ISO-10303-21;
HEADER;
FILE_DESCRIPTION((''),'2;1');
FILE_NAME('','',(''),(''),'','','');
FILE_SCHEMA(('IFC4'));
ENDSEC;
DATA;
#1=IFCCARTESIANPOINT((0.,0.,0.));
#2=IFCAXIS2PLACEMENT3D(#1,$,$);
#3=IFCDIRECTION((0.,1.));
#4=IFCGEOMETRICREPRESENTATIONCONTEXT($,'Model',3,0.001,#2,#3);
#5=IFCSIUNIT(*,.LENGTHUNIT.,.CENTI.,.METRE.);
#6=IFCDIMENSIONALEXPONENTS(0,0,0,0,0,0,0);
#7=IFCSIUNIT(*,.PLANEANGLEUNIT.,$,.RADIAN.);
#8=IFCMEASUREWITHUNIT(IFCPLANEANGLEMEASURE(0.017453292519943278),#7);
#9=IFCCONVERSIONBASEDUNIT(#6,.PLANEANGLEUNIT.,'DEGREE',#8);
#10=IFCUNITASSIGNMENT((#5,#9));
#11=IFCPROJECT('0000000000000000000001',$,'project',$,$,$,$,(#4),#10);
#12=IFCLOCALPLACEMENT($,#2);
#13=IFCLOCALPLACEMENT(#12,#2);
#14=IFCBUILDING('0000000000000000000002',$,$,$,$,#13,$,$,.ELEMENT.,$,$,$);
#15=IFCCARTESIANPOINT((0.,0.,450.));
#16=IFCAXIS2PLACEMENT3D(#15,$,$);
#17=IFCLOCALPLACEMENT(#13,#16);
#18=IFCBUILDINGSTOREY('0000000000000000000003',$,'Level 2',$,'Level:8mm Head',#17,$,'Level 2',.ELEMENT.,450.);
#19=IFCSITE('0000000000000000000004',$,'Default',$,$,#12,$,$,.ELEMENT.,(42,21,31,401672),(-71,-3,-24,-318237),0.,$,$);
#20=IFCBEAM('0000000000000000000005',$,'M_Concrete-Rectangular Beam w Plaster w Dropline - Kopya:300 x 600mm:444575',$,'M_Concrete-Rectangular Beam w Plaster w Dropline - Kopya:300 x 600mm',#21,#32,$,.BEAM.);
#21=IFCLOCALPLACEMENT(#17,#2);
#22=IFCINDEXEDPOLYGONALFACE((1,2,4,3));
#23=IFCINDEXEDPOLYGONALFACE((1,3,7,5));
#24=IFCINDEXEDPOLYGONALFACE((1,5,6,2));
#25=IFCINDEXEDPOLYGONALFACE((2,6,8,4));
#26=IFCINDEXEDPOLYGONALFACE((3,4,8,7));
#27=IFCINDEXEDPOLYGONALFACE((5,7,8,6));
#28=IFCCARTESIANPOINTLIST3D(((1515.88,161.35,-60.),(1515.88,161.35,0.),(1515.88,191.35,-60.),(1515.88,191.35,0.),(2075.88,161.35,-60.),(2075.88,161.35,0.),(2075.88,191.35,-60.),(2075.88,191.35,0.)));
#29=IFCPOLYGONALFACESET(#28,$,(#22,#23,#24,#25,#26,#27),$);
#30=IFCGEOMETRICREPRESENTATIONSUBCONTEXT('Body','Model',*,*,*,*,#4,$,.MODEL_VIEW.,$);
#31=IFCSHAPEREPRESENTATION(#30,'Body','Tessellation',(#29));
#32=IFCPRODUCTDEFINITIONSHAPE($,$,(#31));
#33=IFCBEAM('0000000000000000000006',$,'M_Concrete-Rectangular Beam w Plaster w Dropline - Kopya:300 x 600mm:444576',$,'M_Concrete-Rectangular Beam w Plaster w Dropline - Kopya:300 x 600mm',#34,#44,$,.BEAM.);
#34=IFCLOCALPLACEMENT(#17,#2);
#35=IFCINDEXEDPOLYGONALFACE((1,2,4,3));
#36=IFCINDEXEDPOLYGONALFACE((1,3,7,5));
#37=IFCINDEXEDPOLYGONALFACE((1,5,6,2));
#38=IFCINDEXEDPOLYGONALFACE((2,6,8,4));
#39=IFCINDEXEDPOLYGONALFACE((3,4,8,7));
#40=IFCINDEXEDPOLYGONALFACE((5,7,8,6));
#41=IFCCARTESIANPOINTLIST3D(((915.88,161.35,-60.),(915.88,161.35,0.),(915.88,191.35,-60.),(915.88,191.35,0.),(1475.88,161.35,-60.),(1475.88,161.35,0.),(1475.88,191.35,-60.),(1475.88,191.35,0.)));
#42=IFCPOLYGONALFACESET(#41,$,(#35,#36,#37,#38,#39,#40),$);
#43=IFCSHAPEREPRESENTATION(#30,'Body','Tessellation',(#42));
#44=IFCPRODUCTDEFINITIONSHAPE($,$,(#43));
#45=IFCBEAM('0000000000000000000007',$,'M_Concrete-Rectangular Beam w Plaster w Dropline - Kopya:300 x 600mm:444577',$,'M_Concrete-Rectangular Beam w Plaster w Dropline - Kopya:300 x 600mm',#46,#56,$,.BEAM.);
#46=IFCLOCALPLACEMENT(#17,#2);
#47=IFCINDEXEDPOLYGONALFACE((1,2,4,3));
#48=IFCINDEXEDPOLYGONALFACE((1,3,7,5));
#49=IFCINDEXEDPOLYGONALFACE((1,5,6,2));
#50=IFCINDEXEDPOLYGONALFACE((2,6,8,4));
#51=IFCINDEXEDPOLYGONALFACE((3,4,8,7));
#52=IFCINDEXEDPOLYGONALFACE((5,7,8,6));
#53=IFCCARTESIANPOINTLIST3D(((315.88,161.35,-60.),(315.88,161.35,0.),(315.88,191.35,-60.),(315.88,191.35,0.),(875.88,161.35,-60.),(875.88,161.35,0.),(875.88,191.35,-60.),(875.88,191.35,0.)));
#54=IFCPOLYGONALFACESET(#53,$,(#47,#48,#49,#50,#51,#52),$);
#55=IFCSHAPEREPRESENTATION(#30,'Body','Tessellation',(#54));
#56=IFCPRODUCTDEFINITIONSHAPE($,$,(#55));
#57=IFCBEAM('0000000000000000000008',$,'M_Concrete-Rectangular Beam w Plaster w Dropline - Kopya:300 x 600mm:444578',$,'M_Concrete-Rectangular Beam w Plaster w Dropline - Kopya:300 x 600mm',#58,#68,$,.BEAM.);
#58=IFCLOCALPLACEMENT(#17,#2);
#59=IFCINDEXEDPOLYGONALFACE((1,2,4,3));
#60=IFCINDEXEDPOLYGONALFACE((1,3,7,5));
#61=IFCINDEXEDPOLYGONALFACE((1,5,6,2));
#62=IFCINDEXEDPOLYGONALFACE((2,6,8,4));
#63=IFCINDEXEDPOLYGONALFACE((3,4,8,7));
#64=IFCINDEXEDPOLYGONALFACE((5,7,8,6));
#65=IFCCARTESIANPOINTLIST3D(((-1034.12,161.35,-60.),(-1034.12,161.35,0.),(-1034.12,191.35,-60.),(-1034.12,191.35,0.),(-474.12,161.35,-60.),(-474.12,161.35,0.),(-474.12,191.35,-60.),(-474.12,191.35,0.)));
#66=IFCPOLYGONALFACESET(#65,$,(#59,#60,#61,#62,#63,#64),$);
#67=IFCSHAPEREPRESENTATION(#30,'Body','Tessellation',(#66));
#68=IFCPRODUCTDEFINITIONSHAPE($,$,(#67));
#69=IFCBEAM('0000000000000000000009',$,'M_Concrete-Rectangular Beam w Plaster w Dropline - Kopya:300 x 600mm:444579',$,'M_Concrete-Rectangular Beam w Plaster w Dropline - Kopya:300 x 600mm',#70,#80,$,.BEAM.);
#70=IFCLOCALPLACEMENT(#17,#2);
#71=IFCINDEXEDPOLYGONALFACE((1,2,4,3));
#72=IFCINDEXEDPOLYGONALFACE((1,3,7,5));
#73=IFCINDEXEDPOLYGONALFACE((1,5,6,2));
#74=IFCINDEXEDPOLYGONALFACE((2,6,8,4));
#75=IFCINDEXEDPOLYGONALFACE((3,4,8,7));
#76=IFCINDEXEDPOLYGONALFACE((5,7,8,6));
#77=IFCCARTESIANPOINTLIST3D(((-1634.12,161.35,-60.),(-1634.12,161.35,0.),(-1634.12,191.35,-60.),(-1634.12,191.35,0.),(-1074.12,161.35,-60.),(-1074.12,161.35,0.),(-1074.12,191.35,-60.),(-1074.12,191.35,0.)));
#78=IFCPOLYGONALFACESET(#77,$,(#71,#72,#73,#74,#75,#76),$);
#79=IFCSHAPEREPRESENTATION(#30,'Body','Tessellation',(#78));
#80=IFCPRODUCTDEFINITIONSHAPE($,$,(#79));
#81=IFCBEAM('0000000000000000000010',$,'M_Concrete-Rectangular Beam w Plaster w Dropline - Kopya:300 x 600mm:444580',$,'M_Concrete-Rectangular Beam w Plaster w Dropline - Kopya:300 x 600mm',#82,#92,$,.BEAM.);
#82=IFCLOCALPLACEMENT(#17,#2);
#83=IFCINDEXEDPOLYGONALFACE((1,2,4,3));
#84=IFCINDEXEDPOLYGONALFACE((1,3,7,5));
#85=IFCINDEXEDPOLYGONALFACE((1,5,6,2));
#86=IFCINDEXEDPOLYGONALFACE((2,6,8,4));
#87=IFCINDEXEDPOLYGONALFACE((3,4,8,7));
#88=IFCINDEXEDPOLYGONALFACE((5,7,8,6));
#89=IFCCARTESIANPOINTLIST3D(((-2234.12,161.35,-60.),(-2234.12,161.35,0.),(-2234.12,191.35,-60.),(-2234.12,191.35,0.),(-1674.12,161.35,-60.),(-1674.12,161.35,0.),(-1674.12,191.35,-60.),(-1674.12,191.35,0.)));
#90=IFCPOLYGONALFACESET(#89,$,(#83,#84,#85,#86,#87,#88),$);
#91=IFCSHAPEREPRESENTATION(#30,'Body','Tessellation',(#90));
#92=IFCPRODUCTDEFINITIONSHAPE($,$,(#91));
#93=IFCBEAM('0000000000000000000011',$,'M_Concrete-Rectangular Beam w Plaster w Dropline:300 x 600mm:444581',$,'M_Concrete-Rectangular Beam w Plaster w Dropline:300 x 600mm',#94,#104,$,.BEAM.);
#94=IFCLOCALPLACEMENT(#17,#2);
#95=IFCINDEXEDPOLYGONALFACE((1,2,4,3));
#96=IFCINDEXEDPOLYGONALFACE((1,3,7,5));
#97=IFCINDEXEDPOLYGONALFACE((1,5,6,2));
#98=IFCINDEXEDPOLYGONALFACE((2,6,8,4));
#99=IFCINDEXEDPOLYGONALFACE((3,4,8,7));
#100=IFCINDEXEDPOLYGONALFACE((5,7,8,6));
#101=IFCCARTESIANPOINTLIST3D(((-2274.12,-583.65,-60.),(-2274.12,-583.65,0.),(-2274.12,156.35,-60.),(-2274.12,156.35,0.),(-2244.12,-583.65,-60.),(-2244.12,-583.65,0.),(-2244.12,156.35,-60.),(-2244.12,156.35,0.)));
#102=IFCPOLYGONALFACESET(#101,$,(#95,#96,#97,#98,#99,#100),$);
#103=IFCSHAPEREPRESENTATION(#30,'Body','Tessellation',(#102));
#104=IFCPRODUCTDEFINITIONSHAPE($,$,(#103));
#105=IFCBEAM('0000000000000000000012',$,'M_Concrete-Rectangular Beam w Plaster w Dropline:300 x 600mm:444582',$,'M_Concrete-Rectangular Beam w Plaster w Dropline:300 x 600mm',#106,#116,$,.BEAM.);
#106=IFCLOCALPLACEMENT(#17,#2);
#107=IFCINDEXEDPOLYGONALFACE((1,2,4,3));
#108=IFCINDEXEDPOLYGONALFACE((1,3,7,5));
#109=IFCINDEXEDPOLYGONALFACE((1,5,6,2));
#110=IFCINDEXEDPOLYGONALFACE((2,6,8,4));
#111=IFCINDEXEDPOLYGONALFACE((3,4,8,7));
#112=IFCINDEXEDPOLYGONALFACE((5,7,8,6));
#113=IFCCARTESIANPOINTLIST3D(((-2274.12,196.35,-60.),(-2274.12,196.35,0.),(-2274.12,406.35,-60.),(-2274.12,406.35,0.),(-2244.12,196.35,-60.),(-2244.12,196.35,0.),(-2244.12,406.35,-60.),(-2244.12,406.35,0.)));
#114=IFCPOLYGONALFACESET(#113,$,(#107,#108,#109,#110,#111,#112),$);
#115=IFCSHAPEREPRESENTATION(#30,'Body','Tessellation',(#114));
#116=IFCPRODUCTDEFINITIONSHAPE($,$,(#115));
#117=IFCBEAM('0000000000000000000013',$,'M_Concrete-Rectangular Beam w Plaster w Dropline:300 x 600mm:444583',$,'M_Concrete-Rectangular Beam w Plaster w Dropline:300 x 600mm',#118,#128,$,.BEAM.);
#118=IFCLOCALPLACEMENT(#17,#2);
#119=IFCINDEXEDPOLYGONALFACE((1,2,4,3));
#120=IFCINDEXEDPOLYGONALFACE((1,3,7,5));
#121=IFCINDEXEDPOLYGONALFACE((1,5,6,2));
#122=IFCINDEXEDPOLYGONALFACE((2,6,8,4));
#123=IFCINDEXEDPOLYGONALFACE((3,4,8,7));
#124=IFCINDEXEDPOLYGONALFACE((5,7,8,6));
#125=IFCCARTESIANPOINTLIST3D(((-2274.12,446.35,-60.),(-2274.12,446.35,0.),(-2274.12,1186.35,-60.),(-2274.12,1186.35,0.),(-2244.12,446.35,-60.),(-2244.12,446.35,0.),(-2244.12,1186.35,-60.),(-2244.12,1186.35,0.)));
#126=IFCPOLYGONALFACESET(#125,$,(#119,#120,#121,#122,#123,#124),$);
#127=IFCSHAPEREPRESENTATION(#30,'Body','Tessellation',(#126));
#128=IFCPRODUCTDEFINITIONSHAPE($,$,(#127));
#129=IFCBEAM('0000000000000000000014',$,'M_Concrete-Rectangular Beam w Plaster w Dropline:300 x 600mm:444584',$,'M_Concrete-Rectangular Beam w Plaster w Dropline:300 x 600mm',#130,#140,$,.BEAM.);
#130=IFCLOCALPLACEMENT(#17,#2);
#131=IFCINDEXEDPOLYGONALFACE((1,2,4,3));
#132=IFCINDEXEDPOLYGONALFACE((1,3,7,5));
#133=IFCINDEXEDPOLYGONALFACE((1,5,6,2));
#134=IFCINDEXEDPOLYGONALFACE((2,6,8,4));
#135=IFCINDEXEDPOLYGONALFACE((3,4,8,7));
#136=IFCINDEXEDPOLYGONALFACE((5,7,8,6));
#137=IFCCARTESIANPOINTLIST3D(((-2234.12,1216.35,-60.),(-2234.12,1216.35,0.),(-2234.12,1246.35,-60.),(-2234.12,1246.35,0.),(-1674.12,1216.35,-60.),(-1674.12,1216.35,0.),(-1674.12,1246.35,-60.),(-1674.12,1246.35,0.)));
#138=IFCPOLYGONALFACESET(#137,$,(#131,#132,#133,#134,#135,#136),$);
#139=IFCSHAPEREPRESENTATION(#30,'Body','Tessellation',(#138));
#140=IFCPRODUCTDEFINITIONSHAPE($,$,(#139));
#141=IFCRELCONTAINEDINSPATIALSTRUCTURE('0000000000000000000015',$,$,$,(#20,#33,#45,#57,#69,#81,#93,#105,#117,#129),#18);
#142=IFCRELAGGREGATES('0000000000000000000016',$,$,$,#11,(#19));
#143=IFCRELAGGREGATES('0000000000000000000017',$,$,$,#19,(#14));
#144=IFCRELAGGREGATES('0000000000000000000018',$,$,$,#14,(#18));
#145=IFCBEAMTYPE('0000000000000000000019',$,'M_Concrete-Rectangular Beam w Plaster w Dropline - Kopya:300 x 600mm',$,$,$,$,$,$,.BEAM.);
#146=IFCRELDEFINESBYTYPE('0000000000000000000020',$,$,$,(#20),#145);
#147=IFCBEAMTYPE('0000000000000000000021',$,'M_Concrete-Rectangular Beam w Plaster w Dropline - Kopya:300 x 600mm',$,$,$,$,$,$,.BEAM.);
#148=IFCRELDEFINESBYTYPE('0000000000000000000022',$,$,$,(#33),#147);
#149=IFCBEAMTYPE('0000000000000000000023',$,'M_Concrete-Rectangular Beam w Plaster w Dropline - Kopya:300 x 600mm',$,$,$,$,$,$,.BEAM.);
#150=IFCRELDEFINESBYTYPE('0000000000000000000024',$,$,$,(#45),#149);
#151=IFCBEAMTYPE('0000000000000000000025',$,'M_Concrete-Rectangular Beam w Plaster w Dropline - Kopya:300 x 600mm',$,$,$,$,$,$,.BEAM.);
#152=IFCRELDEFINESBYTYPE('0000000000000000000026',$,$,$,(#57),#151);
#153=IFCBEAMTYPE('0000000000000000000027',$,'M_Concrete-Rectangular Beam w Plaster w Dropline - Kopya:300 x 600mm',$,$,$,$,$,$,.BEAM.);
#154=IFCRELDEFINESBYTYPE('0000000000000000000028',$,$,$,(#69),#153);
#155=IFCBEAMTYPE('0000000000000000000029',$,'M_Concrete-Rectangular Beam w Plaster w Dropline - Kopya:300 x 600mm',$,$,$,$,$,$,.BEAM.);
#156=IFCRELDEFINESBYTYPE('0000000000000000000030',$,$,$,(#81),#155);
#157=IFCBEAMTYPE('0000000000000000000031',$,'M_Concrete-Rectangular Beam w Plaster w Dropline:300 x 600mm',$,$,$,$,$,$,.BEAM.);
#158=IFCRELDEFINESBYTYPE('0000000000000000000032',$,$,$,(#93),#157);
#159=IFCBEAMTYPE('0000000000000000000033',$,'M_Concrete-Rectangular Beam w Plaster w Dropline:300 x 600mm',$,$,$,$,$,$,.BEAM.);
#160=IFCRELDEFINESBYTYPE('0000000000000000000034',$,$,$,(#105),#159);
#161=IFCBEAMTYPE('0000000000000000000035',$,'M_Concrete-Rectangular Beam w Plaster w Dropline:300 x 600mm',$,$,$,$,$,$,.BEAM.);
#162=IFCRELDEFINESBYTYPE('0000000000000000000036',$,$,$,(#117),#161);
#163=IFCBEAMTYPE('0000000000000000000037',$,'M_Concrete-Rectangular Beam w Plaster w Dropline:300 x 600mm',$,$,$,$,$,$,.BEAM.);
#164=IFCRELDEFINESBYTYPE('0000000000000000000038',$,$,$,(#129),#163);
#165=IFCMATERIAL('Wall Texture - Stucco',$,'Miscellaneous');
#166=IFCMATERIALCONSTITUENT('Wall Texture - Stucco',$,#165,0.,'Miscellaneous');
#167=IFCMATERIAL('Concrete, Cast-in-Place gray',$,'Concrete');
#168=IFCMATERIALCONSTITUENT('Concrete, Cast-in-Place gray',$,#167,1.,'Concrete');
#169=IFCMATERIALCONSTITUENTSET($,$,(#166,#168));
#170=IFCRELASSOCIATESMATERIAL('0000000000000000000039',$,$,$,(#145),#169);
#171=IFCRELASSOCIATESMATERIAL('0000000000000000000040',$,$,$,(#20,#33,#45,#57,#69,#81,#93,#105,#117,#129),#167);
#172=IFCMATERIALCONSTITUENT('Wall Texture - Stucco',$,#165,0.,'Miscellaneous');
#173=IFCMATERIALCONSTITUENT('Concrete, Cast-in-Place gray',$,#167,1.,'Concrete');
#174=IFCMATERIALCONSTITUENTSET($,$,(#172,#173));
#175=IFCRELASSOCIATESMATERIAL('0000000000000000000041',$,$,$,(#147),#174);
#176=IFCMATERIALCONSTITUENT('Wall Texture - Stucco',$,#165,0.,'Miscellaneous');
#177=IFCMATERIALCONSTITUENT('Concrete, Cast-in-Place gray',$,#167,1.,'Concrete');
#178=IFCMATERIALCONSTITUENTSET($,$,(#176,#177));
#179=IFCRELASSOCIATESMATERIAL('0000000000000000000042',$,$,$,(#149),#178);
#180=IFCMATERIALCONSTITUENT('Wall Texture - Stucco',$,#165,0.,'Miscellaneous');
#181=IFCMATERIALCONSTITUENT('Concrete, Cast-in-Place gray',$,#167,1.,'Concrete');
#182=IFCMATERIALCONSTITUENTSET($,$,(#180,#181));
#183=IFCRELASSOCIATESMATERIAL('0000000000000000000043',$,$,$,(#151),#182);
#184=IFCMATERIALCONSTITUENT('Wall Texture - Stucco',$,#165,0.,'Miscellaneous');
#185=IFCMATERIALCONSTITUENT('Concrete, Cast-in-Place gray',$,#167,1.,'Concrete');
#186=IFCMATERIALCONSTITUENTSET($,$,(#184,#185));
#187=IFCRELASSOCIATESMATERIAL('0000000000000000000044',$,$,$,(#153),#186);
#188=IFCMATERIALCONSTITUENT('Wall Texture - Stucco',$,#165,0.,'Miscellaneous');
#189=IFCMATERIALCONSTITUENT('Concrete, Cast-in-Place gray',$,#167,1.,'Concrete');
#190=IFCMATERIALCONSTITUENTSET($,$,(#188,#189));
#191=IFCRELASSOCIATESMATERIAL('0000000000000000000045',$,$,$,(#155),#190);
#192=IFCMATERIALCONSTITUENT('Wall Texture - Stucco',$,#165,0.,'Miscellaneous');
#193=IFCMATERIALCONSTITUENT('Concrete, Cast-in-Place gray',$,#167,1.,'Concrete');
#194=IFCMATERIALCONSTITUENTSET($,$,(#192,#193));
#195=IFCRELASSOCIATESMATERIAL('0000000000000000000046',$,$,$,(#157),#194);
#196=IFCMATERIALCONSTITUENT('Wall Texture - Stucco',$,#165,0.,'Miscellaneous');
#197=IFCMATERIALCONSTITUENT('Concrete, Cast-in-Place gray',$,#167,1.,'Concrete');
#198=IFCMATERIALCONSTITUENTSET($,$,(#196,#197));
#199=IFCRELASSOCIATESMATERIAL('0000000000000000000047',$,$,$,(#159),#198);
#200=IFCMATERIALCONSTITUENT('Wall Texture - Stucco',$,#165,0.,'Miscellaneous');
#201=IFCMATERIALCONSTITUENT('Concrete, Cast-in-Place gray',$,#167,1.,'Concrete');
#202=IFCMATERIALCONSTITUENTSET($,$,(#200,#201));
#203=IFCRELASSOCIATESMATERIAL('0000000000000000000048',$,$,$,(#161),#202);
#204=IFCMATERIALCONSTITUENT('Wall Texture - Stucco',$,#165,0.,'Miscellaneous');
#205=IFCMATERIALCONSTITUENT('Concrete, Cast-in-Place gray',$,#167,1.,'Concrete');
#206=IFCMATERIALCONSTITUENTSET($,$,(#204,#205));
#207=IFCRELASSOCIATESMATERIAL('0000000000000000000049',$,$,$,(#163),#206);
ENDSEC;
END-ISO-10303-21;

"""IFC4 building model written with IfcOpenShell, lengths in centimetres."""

from ifc_helpers import new_model, entity, si_unit, converted_unit, direction, frame, origin, place, context, subcontext, project, spatial, indexed_curve, outline, extrude, source, transform, mapped, material, constituent, constituent_set, type_object, type_shapes, element, save


model = new_model("IFC4")

# Units and contexts
model_context = context("Model", 3, precision=0.001, world=origin(), true_north=direction((0.0, 1.0)))
body_context = subcontext(model_context, "Body", "Model", "MODEL_VIEW")
ifc_project = project(units=[si_unit("LENGTHUNIT", "METRE", prefix="CENTI"), converted_unit("PLANEANGLEUNIT", "DEGREE", entity("IfcPlaneAngleMeasure", 0.017453292519943278), si_unit("PLANEANGLEUNIT", "RADIAN"), dimensions=[0, 0, 0, 0, 0, 0, 0])], contexts=[model_context])

# Site, building, storey
site_placement = place(None, origin())
site = spatial("IfcSite", under=ifc_project, at=site_placement, Name="Default", CompositionType="ELEMENT", RefLatitude=(42, 21, 31, 401672), RefLongitude=(-71, -3, -24, -318237), RefElevation=0.0)
building_placement = place(site_placement, origin())
building = spatial("IfcBuilding", under=site, at=building_placement, CompositionType="ELEMENT")
storey_placement = place(building_placement, frame((0.0, 0.0, 450.0)))
storey = spatial("IfcBuildingStorey", under=building, at=storey_placement, Name="Level 2", ObjectType="Level:8mm Head", LongName="Level 2", CompositionType="ELEMENT", Elevation=450.0)

# Beams
ifc_material_1 = material(Name="Concrete, Cast-in-Place gray", Category="Concrete")
ifc_material_2 = material(Name="Wall Texture - Stucco", Category="Miscellaneous")
ifc_constituent_1 = constituent(ifc_material_2, Name="Wall Texture - Stucco", Category="Miscellaneous", fraction=0.0)
ifc_constituent_2 = constituent(ifc_material_1, Name="Concrete, Cast-in-Place gray", Category="Concrete", fraction=1.0)
ifc_constituent_set_1 = constituent_set(constituents=[ifc_constituent_1, ifc_constituent_2])
beam_type_1 = type_object("IfcBeamType", Name="M_Concrete-Rectangular Beam w Plaster w Dropline - Kopya:300 x 600mm", PredefinedType="BEAM", material=ifc_constituent_set_1)
shared_shape_1 = source(origin(), body_context, "Body", "SweptSolid", [
    extrude(outline(indexed_curve([(-30.0, -15.0), (30.0, -15.0), (30.0, 15.0), (-30.0, 15.0), (-30.0, -15.0)], self_intersect=False)), frame((2075.88, 176.35, 420.0), z_axis=(-1.0, 0.0, 0.0), x_axis=(0.0, 0.0, -1.0)), (0.0, 0.0, 1.0), 560.0),
])
type_shapes(beam_type_1, [shared_shape_1])
beam_1_placement = place(storey_placement, frame((0.0, 0.0, -450.0)))
element("IfcBeam", 1, at=beam_1_placement, inside=storey, type_object=beam_type_1, material=ifc_material_1, Name="M_Concrete-Rectangular Beam w Plaster w Dropline - Kopya:300 x 600mm:444575", ObjectType="M_Concrete-Rectangular Beam w Plaster w Dropline - Kopya:300 x 600mm", PredefinedType="BEAM", context=body_context, shape_type="MappedRepresentation", body=[
    mapped(shared_shape_1, transform((0.0, 0.0, 0.0), scale=1.0)),
])
ifc_constituent_3 = constituent(ifc_material_2, Name="Wall Texture - Stucco", Category="Miscellaneous", fraction=0.0)
ifc_constituent_4 = constituent(ifc_material_1, Name="Concrete, Cast-in-Place gray", Category="Concrete", fraction=1.0)
ifc_constituent_set_2 = constituent_set(constituents=[ifc_constituent_3, ifc_constituent_4])
beam_type_2 = type_object("IfcBeamType", Name="M_Concrete-Rectangular Beam w Plaster w Dropline - Kopya:300 x 600mm", PredefinedType="BEAM", material=ifc_constituent_set_2)
shared_shape_2 = source(origin(), body_context, "Body", "SweptSolid", [
    extrude(outline(indexed_curve([(-30.0, -15.0), (30.0, -15.0), (30.0, 15.0), (-30.0, 15.0), (-30.0, -15.0)], self_intersect=False)), frame((1475.88, 176.35, 420.0), z_axis=(-1.0, 0.0, 0.0), x_axis=(0.0, 0.0, -1.0)), (0.0, 0.0, 1.0), 560.0),
])
type_shapes(beam_type_2, [shared_shape_2])
beam_2_placement = place(storey_placement, frame((0.0, 0.0, -450.0)))
element("IfcBeam", 2, at=beam_2_placement, inside=storey, type_object=beam_type_2, material=ifc_material_1, Name="M_Concrete-Rectangular Beam w Plaster w Dropline - Kopya:300 x 600mm:444576", ObjectType="M_Concrete-Rectangular Beam w Plaster w Dropline - Kopya:300 x 600mm", PredefinedType="BEAM", context=body_context, shape_type="MappedRepresentation", body=[
    mapped(shared_shape_2, transform((0.0, 0.0, 0.0), scale=1.0)),
])
ifc_constituent_5 = constituent(ifc_material_2, Name="Wall Texture - Stucco", Category="Miscellaneous", fraction=0.0)
ifc_constituent_6 = constituent(ifc_material_1, Name="Concrete, Cast-in-Place gray", Category="Concrete", fraction=1.0)
ifc_constituent_set_3 = constituent_set(constituents=[ifc_constituent_5, ifc_constituent_6])
beam_type_3 = type_object("IfcBeamType", Name="M_Concrete-Rectangular Beam w Plaster w Dropline - Kopya:300 x 600mm", PredefinedType="BEAM", material=ifc_constituent_set_3)
shared_shape_3 = source(origin(), body_context, "Body", "SweptSolid", [
    extrude(outline(indexed_curve([(-30.0, -15.0), (30.0, -15.0), (30.0, 15.0), (-30.0, 15.0), (-30.0, -15.0)], self_intersect=False)), frame((875.88, 176.35, 420.0), z_axis=(-1.0, 0.0, 0.0), x_axis=(0.0, 0.0, -1.0)), (0.0, 0.0, 1.0), 560.0),
])
type_shapes(beam_type_3, [shared_shape_3])
beam_3_placement = place(storey_placement, frame((0.0, 0.0, -450.0)))
element("IfcBeam", 3, at=beam_3_placement, inside=storey, type_object=beam_type_3, material=ifc_material_1, Name="M_Concrete-Rectangular Beam w Plaster w Dropline - Kopya:300 x 600mm:444577", ObjectType="M_Concrete-Rectangular Beam w Plaster w Dropline - Kopya:300 x 600mm", PredefinedType="BEAM", context=body_context, shape_type="MappedRepresentation", body=[
    mapped(shared_shape_3, transform((0.0, 0.0, 0.0), scale=1.0)),
])
ifc_constituent_7 = constituent(ifc_material_2, Name="Wall Texture - Stucco", Category="Miscellaneous", fraction=0.0)
ifc_constituent_8 = constituent(ifc_material_1, Name="Concrete, Cast-in-Place gray", Category="Concrete", fraction=1.0)
ifc_constituent_set_4 = constituent_set(constituents=[ifc_constituent_7, ifc_constituent_8])
beam_type_4 = type_object("IfcBeamType", Name="M_Concrete-Rectangular Beam w Plaster w Dropline - Kopya:300 x 600mm", PredefinedType="BEAM", material=ifc_constituent_set_4)
shared_shape_4 = source(origin(), body_context, "Body", "SweptSolid", [
    extrude(outline(indexed_curve([(-30.0, -15.0), (30.0, -15.0), (30.0, 15.0), (-30.0, 15.0), (-30.0, -15.0)], self_intersect=False)), frame((-474.12, 176.35, 420.0), z_axis=(-1.0, 0.0, 0.0), x_axis=(0.0, 0.0, -1.0)), (0.0, 0.0, 1.0), 560.0),
])
type_shapes(beam_type_4, [shared_shape_4])
beam_4_placement = place(storey_placement, frame((0.0, 0.0, -450.0)))
element("IfcBeam", 4, at=beam_4_placement, inside=storey, type_object=beam_type_4, material=ifc_material_1, Name="M_Concrete-Rectangular Beam w Plaster w Dropline - Kopya:300 x 600mm:444578", ObjectType="M_Concrete-Rectangular Beam w Plaster w Dropline - Kopya:300 x 600mm", PredefinedType="BEAM", context=body_context, shape_type="MappedRepresentation", body=[
    mapped(shared_shape_4, transform((0.0, 0.0, 0.0), scale=1.0)),
])
ifc_constituent_9 = constituent(ifc_material_2, Name="Wall Texture - Stucco", Category="Miscellaneous", fraction=0.0)
ifc_constituent_10 = constituent(ifc_material_1, Name="Concrete, Cast-in-Place gray", Category="Concrete", fraction=1.0)
ifc_constituent_set_5 = constituent_set(constituents=[ifc_constituent_9, ifc_constituent_10])
beam_type_5 = type_object("IfcBeamType", Name="M_Concrete-Rectangular Beam w Plaster w Dropline - Kopya:300 x 600mm", PredefinedType="BEAM", material=ifc_constituent_set_5)
shared_shape_5 = source(origin(), body_context, "Body", "SweptSolid", [
    extrude(outline(indexed_curve([(-30.0, -15.0), (30.0, -15.0), (30.0, 15.0), (-30.0, 15.0), (-30.0, -15.0)], self_intersect=False)), frame((-1074.12, 176.35, 420.0), z_axis=(-1.0, 0.0, 0.0), x_axis=(0.0, 0.0, -1.0)), (0.0, 0.0, 1.0), 560.0),
])
type_shapes(beam_type_5, [shared_shape_5])
beam_5_placement = place(storey_placement, frame((0.0, 0.0, -450.0)))
element("IfcBeam", 5, at=beam_5_placement, inside=storey, type_object=beam_type_5, material=ifc_material_1, Name="M_Concrete-Rectangular Beam w Plaster w Dropline - Kopya:300 x 600mm:444579", ObjectType="M_Concrete-Rectangular Beam w Plaster w Dropline - Kopya:300 x 600mm", PredefinedType="BEAM", context=body_context, shape_type="MappedRepresentation", body=[
    mapped(shared_shape_5, transform((0.0, 0.0, 0.0), scale=1.0)),
])
ifc_constituent_11 = constituent(ifc_material_2, Name="Wall Texture - Stucco", Category="Miscellaneous", fraction=0.0)
ifc_constituent_12 = constituent(ifc_material_1, Name="Concrete, Cast-in-Place gray", Category="Concrete", fraction=1.0)
ifc_constituent_set_6 = constituent_set(constituents=[ifc_constituent_11, ifc_constituent_12])
beam_type_6 = type_object("IfcBeamType", Name="M_Concrete-Rectangular Beam w Plaster w Dropline - Kopya:300 x 600mm", PredefinedType="BEAM", material=ifc_constituent_set_6)
shared_shape_6 = source(origin(), body_context, "Body", "SweptSolid", [
    extrude(outline(indexed_curve([(-30.0, -15.0), (30.0, -15.0), (30.0, 15.0), (-30.0, 15.0), (-30.0, -15.0)], self_intersect=False)), frame((-1674.12, 176.35, 420.0), z_axis=(-1.0, 0.0, 0.0), x_axis=(0.0, 0.0, -1.0)), (0.0, 0.0, 1.0), 560.0),
])
type_shapes(beam_type_6, [shared_shape_6])
beam_6_placement = place(storey_placement, frame((0.0, 0.0, -450.0)))
element("IfcBeam", 6, at=beam_6_placement, inside=storey, type_object=beam_type_6, material=ifc_material_1, Name="M_Concrete-Rectangular Beam w Plaster w Dropline - Kopya:300 x 600mm:444580", ObjectType="M_Concrete-Rectangular Beam w Plaster w Dropline - Kopya:300 x 600mm", PredefinedType="BEAM", context=body_context, shape_type="MappedRepresentation", body=[
    mapped(shared_shape_6, transform((0.0, 0.0, 0.0), scale=1.0)),
])
ifc_constituent_13 = constituent(ifc_material_2, Name="Wall Texture - Stucco", Category="Miscellaneous", fraction=0.0)
ifc_constituent_14 = constituent(ifc_material_1, Name="Concrete, Cast-in-Place gray", Category="Concrete", fraction=1.0)
ifc_constituent_set_7 = constituent_set(constituents=[ifc_constituent_13, ifc_constituent_14])
beam_type_7 = type_object("IfcBeamType", Name="M_Concrete-Rectangular Beam w Plaster w Dropline:300 x 600mm", PredefinedType="BEAM", material=ifc_constituent_set_7)
shared_shape_7 = source(origin(), body_context, "Body", "SweptSolid", [
    extrude(outline(indexed_curve([(-15.0, -30.0), (15.0, -30.0), (15.0, 30.0), (-15.0, 30.0), (-15.0, -30.0)], self_intersect=False)), frame((-2259.12, -583.65, 420.0), z_axis=(0.0, 1.0, 0.0), x_axis=(-1.0, 0.0, 0.0)), (0.0, 0.0, 1.0), 740.0),
])
type_shapes(beam_type_7, [shared_shape_7])
beam_7_placement = place(storey_placement, frame((0.0, 0.0, -450.0)))
element("IfcBeam", 7, at=beam_7_placement, inside=storey, type_object=beam_type_7, material=ifc_material_1, Name="M_Concrete-Rectangular Beam w Plaster w Dropline:300 x 600mm:444581", ObjectType="M_Concrete-Rectangular Beam w Plaster w Dropline:300 x 600mm", PredefinedType="BEAM", context=body_context, shape_type="MappedRepresentation", body=[
    mapped(shared_shape_7, transform((0.0, 0.0, 0.0), scale=1.0)),
])
ifc_constituent_15 = constituent(ifc_material_2, Name="Wall Texture - Stucco", Category="Miscellaneous", fraction=0.0)
ifc_constituent_16 = constituent(ifc_material_1, Name="Concrete, Cast-in-Place gray", Category="Concrete", fraction=1.0)
ifc_constituent_set_8 = constituent_set(constituents=[ifc_constituent_15, ifc_constituent_16])
beam_type_8 = type_object("IfcBeamType", Name="M_Concrete-Rectangular Beam w Plaster w Dropline:300 x 600mm", PredefinedType="BEAM", material=ifc_constituent_set_8)
shared_shape_8 = source(origin(), body_context, "Body", "SweptSolid", [
    extrude(outline(indexed_curve([(-15.0, -30.0), (15.0, -30.0), (15.0, 30.0), (-15.0, 30.0), (-15.0, -30.0)], self_intersect=False)), frame((-2259.12, 196.35, 420.0), z_axis=(0.0, 1.0, 0.0), x_axis=(-1.0, 0.0, 0.0)), (0.0, 0.0, 1.0), 210.0),
])
type_shapes(beam_type_8, [shared_shape_8])
beam_8_placement = place(storey_placement, frame((0.0, 0.0, -450.0)))
element("IfcBeam", 8, at=beam_8_placement, inside=storey, type_object=beam_type_8, material=ifc_material_1, Name="M_Concrete-Rectangular Beam w Plaster w Dropline:300 x 600mm:444582", ObjectType="M_Concrete-Rectangular Beam w Plaster w Dropline:300 x 600mm", PredefinedType="BEAM", context=body_context, shape_type="MappedRepresentation", body=[
    mapped(shared_shape_8, transform((0.0, 0.0, 0.0), scale=1.0)),
])
ifc_constituent_17 = constituent(ifc_material_2, Name="Wall Texture - Stucco", Category="Miscellaneous", fraction=0.0)
ifc_constituent_18 = constituent(ifc_material_1, Name="Concrete, Cast-in-Place gray", Category="Concrete", fraction=1.0)
ifc_constituent_set_9 = constituent_set(constituents=[ifc_constituent_17, ifc_constituent_18])
beam_type_9 = type_object("IfcBeamType", Name="M_Concrete-Rectangular Beam w Plaster w Dropline:300 x 600mm", PredefinedType="BEAM", material=ifc_constituent_set_9)
shared_shape_9 = source(origin(), body_context, "Body", "SweptSolid", [
    extrude(outline(indexed_curve([(-15.0, -30.0), (15.0, -30.0), (15.0, 30.0), (-15.0, 30.0), (-15.0, -30.0)], self_intersect=False)), frame((-2259.12, 446.35, 420.0), z_axis=(0.0, 1.0, 0.0), x_axis=(-1.0, 0.0, 0.0)), (0.0, 0.0, 1.0), 740.0),
])
type_shapes(beam_type_9, [shared_shape_9])
beam_9_placement = place(storey_placement, frame((0.0, 0.0, -450.0)))
element("IfcBeam", 9, at=beam_9_placement, inside=storey, type_object=beam_type_9, material=ifc_material_1, Name="M_Concrete-Rectangular Beam w Plaster w Dropline:300 x 600mm:444583", ObjectType="M_Concrete-Rectangular Beam w Plaster w Dropline:300 x 600mm", PredefinedType="BEAM", context=body_context, shape_type="MappedRepresentation", body=[
    mapped(shared_shape_9, transform((0.0, 0.0, 0.0), scale=1.0)),
])
ifc_constituent_19 = constituent(ifc_material_2, Name="Wall Texture - Stucco", Category="Miscellaneous", fraction=0.0)
ifc_constituent_20 = constituent(ifc_material_1, Name="Concrete, Cast-in-Place gray", Category="Concrete", fraction=1.0)
ifc_constituent_set_10 = constituent_set(constituents=[ifc_constituent_19, ifc_constituent_20])
beam_type_10 = type_object("IfcBeamType", Name="M_Concrete-Rectangular Beam w Plaster w Dropline:300 x 600mm", PredefinedType="BEAM", material=ifc_constituent_set_10)
shared_shape_10 = source(origin(), body_context, "Body", "SweptSolid", [
    extrude(outline(indexed_curve([(-30.0, -15.0), (30.0, -15.0), (30.0, 15.0), (-30.0, 15.0), (-30.0, -15.0)], self_intersect=False)), frame((-2234.12, 1231.35, 420.0), z_axis=(1.0, 0.0, 0.0), x_axis=(0.0, 0.0, -1.0)), (0.0, 0.0, 1.0), 560.0),
])
type_shapes(beam_type_10, [shared_shape_10])
beam_10_placement = place(storey_placement, frame((0.0, 0.0, -450.0)))
element("IfcBeam", 10, at=beam_10_placement, inside=storey, type_object=beam_type_10, material=ifc_material_1, Name="M_Concrete-Rectangular Beam w Plaster w Dropline:300 x 600mm:444584", ObjectType="M_Concrete-Rectangular Beam w Plaster w Dropline:300 x 600mm", PredefinedType="BEAM", context=body_context, shape_type="MappedRepresentation", body=[
    mapped(shared_shape_10, transform((0.0, 0.0, 0.0), scale=1.0)),
])

save(model, "model.ifc")
